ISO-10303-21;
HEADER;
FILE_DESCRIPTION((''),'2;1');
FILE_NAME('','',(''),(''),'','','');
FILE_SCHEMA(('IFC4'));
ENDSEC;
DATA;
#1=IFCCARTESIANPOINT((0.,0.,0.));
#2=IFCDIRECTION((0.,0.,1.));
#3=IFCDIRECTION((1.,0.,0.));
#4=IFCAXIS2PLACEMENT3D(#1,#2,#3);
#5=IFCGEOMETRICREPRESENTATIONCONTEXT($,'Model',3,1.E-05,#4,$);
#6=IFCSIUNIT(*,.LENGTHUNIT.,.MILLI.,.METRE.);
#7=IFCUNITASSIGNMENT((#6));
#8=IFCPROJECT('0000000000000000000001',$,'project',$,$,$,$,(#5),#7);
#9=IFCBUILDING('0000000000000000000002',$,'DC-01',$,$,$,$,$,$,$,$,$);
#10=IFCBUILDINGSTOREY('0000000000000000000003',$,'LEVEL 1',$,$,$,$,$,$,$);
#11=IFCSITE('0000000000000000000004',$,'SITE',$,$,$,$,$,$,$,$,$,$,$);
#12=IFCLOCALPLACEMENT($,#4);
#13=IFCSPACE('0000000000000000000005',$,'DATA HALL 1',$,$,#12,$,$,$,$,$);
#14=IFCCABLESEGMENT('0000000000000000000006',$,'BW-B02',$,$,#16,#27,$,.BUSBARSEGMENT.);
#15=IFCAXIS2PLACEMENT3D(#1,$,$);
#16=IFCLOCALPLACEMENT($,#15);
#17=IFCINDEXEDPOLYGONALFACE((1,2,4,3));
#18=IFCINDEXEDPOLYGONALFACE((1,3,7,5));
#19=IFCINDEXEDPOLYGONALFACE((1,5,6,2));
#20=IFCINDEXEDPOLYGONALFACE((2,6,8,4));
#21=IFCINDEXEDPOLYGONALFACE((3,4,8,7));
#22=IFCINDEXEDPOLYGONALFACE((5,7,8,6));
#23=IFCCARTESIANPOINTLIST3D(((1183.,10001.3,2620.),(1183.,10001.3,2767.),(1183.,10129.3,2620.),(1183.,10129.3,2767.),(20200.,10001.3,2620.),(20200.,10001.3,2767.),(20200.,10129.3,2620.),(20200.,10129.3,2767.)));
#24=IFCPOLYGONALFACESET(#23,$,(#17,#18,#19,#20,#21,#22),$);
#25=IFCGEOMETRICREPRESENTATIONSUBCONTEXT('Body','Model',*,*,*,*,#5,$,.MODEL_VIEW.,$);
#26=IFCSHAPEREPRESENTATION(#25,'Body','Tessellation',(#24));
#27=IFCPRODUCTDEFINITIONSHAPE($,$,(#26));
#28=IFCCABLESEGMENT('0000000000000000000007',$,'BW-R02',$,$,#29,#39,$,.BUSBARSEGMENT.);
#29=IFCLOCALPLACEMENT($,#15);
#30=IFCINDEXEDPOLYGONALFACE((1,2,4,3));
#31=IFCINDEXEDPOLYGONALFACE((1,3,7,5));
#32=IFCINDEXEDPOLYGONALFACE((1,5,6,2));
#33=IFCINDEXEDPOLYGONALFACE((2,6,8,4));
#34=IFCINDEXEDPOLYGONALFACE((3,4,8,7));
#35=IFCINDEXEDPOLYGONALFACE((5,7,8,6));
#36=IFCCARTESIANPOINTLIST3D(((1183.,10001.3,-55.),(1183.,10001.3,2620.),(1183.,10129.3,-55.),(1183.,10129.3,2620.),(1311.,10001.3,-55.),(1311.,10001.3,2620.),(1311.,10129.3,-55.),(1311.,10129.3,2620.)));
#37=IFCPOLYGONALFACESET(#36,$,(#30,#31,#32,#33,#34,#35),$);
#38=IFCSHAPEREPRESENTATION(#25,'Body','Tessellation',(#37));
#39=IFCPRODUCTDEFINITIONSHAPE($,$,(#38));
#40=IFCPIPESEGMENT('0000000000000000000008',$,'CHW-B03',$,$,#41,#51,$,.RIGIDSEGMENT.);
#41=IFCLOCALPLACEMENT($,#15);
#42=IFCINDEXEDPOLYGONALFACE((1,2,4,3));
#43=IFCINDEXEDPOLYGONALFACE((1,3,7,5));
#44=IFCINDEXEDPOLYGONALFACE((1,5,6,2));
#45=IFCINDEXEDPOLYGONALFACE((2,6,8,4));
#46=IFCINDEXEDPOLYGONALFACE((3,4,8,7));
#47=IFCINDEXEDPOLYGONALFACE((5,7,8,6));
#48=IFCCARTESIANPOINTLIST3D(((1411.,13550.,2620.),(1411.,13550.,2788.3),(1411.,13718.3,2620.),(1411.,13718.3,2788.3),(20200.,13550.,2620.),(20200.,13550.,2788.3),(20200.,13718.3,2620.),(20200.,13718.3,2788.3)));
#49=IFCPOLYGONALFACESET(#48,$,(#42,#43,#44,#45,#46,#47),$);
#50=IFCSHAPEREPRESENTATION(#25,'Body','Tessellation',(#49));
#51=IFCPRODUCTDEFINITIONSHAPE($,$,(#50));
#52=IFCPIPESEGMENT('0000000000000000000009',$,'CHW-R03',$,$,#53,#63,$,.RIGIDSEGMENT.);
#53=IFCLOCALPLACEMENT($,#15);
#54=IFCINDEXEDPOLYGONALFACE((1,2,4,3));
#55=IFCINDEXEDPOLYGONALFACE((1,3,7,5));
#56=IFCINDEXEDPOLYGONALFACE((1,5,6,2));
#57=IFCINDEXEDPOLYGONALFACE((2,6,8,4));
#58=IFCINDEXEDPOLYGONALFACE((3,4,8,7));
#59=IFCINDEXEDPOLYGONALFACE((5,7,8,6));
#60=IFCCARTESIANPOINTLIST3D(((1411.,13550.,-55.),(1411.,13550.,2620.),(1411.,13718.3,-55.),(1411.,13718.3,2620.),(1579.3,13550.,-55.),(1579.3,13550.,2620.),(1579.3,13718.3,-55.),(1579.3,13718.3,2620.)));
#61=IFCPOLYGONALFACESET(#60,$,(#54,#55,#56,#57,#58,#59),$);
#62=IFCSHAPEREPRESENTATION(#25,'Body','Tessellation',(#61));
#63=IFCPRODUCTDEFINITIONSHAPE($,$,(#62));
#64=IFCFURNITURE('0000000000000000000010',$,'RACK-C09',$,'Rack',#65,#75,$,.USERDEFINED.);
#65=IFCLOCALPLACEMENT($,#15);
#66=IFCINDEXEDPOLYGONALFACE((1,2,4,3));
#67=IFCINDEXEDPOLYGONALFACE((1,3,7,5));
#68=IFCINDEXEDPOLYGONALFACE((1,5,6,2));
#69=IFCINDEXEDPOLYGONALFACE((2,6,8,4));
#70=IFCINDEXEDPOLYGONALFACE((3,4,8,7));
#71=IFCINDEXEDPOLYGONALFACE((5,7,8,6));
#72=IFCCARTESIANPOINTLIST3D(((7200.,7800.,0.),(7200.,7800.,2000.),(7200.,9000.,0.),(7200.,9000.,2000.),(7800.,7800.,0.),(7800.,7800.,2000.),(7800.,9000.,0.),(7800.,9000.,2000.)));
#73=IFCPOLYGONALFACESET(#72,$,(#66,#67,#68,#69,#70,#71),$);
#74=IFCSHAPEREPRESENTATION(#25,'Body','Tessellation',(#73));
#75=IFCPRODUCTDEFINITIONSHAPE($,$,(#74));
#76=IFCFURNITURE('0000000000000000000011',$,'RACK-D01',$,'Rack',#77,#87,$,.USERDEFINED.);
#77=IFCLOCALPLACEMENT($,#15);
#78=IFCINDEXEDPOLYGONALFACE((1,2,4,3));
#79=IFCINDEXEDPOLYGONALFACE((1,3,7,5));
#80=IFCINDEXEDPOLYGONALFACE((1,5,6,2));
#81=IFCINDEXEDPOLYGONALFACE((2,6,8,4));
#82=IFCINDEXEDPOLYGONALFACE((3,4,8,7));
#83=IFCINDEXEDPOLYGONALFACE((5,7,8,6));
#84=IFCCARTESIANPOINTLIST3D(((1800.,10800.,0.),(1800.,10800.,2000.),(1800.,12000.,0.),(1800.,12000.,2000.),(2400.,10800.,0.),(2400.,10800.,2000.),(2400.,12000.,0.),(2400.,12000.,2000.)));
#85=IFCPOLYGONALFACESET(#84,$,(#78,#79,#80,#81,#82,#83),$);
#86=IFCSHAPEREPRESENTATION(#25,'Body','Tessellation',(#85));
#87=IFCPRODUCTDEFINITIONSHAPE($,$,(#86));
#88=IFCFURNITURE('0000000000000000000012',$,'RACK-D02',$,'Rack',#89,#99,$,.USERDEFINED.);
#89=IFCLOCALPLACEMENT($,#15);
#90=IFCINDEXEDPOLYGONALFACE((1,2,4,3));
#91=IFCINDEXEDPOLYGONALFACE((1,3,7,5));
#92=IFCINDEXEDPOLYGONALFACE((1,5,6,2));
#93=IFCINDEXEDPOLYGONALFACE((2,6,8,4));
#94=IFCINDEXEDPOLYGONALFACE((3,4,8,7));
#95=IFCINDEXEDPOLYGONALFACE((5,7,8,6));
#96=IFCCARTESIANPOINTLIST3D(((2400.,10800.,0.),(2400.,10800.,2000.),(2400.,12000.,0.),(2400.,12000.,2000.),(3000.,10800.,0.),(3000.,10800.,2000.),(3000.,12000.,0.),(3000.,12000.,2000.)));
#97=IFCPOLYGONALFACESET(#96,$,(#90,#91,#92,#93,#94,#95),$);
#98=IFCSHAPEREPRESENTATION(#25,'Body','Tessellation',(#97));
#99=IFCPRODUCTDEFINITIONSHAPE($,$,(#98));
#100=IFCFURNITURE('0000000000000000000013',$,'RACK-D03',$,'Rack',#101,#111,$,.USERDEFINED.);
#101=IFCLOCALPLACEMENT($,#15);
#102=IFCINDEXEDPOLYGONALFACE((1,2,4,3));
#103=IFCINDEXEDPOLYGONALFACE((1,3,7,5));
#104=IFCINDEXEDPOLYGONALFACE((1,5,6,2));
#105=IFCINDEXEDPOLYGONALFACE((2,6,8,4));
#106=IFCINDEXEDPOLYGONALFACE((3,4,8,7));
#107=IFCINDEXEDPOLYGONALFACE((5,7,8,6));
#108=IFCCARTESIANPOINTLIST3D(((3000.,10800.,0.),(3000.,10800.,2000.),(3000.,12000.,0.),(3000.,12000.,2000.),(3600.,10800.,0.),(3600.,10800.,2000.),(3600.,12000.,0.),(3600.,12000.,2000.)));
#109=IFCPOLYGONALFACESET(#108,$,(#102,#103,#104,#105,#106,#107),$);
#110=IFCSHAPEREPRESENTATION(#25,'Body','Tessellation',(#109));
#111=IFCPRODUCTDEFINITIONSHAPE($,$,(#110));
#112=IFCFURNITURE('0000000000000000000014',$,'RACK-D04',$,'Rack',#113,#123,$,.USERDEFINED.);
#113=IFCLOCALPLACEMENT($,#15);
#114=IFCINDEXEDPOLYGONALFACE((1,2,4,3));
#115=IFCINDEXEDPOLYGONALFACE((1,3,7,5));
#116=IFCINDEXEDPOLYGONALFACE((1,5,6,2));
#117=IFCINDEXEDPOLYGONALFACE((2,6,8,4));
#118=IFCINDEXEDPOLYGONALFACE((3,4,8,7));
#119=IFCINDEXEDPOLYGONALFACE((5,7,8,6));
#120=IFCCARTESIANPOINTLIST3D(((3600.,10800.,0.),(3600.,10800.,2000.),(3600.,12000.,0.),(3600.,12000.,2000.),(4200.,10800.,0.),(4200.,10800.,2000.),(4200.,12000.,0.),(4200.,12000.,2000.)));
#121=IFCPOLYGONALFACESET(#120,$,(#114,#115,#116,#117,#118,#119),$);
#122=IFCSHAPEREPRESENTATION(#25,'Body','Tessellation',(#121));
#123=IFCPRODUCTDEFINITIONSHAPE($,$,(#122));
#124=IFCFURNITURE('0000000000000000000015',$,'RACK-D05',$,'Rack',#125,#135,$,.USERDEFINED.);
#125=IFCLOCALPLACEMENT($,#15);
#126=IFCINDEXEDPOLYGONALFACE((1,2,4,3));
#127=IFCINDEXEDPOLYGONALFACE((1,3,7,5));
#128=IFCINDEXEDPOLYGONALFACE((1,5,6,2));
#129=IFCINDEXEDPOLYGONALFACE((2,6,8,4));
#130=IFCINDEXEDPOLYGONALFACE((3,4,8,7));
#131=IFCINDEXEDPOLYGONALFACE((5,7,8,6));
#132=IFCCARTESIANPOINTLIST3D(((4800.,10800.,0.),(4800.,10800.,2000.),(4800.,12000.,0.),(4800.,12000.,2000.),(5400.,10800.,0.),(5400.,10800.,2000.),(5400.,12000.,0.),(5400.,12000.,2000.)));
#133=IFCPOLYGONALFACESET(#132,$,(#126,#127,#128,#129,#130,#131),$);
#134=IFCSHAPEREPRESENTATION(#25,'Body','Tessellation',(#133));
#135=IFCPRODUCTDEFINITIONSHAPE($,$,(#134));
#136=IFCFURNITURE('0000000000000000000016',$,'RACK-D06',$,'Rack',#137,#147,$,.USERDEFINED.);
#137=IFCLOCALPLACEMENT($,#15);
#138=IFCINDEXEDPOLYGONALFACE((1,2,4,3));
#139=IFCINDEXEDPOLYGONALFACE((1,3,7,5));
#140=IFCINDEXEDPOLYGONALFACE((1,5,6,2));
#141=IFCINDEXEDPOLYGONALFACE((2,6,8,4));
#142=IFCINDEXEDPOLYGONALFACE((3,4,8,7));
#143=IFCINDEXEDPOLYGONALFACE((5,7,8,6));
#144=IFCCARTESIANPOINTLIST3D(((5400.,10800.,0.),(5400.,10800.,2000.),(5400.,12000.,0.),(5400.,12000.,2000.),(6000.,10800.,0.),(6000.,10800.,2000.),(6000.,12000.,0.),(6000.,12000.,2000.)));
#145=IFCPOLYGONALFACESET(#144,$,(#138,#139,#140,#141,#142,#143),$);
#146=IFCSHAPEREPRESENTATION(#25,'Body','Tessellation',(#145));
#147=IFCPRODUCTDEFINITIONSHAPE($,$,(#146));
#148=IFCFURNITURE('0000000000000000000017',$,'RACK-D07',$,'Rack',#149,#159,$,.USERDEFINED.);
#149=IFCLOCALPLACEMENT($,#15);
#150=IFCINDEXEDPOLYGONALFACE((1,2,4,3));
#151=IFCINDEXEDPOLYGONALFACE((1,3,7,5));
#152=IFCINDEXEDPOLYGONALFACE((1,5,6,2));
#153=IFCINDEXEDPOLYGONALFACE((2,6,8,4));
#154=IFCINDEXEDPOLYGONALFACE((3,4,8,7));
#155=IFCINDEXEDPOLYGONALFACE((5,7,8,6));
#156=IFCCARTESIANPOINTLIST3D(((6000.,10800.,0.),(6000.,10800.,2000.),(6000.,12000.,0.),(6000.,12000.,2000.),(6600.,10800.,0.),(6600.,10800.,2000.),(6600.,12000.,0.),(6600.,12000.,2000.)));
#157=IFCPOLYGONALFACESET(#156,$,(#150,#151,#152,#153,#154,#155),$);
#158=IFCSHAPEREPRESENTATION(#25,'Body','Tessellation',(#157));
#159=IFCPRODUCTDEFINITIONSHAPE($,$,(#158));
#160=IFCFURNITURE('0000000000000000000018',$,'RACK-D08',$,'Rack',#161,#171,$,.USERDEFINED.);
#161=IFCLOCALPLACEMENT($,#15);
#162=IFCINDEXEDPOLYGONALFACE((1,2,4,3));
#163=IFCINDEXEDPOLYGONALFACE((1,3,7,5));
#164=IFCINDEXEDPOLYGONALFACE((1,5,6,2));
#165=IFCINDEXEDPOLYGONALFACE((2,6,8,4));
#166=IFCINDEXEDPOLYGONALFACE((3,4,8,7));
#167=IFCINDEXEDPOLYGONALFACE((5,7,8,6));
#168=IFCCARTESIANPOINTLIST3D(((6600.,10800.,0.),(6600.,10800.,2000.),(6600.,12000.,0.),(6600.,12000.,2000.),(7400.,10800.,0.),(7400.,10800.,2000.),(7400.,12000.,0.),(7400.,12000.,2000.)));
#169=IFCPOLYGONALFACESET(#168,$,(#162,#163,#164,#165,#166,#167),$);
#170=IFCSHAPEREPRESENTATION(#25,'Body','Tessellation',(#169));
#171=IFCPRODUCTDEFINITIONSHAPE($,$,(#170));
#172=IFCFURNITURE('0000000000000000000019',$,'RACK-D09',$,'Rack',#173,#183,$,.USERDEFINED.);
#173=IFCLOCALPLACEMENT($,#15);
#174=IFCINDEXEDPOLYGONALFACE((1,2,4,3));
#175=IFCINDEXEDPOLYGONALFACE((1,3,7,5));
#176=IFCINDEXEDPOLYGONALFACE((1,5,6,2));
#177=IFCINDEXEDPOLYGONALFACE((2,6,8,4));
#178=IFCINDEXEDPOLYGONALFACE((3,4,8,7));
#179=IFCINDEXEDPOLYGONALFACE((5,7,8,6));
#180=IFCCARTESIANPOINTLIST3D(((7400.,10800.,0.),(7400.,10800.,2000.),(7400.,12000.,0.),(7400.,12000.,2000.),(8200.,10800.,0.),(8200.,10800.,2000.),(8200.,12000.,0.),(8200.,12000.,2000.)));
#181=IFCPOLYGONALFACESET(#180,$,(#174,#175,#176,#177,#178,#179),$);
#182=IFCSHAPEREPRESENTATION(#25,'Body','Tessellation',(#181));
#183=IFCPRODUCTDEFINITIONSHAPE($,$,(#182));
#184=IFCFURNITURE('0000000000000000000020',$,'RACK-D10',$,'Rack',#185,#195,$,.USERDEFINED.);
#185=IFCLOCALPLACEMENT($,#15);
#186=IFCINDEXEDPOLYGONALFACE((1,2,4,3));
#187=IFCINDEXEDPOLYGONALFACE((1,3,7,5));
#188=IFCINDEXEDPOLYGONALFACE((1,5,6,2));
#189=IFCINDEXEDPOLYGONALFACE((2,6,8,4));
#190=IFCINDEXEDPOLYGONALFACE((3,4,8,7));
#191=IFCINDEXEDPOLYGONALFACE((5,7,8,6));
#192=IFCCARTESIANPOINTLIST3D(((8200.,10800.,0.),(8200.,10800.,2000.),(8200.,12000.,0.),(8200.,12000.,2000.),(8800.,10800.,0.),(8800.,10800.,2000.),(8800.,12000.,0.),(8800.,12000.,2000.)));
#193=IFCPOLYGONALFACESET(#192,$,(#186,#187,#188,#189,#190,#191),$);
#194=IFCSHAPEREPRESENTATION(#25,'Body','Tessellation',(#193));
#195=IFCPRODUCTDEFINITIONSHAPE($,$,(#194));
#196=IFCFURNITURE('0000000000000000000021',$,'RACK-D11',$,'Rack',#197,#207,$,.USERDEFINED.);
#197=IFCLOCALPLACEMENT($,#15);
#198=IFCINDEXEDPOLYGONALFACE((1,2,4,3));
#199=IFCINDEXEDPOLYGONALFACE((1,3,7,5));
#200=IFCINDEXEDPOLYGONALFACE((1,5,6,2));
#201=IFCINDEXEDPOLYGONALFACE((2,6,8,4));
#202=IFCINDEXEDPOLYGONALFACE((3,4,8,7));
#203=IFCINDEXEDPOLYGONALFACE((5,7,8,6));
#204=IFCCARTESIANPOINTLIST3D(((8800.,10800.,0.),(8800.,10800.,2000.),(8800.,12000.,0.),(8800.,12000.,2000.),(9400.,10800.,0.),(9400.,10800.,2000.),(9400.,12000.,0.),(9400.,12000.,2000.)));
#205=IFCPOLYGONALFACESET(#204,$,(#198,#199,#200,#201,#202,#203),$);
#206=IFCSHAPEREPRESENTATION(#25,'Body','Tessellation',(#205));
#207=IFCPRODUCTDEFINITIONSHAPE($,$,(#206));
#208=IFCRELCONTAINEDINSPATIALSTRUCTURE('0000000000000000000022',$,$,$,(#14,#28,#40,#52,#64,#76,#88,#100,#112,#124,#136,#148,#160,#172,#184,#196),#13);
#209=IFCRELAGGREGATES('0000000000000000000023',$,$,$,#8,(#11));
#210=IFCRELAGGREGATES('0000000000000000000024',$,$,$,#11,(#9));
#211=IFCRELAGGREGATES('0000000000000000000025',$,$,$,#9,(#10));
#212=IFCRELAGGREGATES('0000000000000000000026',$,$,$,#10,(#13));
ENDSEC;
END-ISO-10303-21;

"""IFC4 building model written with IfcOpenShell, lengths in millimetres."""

from ifc_helpers import new_model, si_unit, frame, origin, origin_with_axes, place, context, subcontext, project, spatial, polyline, outline, extrude, element, save


model = new_model("IFC4")

# Units and contexts
model_context = context("Model", 3, precision=1e-05, world=origin_with_axes())
body_context = subcontext(model_context, "Body", "Model", "MODEL_VIEW")
ifc_project = project(units=[si_unit("LENGTHUNIT", "METRE", prefix="MILLI")], contexts=[model_context])

# Site, building, storey, space
site = spatial("IfcSite", under=ifc_project, Name="SITE")
building = spatial("IfcBuilding", under=site, Name="DC-01")
storey = spatial("IfcBuildingStorey", under=building, Name="LEVEL 1")
space_placement = place(None, origin_with_axes())
space = spatial("IfcSpace", under=storey, at=space_placement, Name="DATA HALL 1")

# Cable segments
cable_segment_1_placement = place(space_placement, frame((1183.0, 10001.3, 2620.0), z_axis=(0.0, 0.0, 1.0), x_axis=(1.0, 0.0, 0.0)))
element("IfcCableSegment", 1, at=cable_segment_1_placement, inside=space, Name="BW-B02", PredefinedType="BUSBARSEGMENT", context=body_context, shape_type="SweptSolid", body=[
    extrude(outline(polyline([(0.0, 0.0), (19017.0, 0.0), (19017.0, 128.0), (0.0, 128.0), (0.0, 0.0)])), origin(), (0.0, 0.0, 1.0), 147.0),
])
cable_segment_2_placement = place(space_placement, frame((1183.0, 10001.3, -55.0), z_axis=(0.0, 0.0, 1.0), x_axis=(1.0, 0.0, 0.0)))
element("IfcCableSegment", 2, at=cable_segment_2_placement, inside=space, Name="BW-R02", PredefinedType="BUSBARSEGMENT", context=body_context, shape_type="SweptSolid", body=[
    extrude(outline(polyline([(0.0, 0.0), (128.0, 0.0), (128.0, 128.0), (0.0, 128.0), (0.0, 0.0)])), origin(), (0.0, 0.0, 1.0), 2675.0),
])

# Pipe segments
pipe_segment_1_placement = place(space_placement, frame((1411.0, 13550.0, 2620.0), z_axis=(0.0, 0.0, 1.0), x_axis=(1.0, 0.0, 0.0)))
element("IfcPipeSegment", 3, at=pipe_segment_1_placement, inside=space, Name="CHW-B03", PredefinedType="RIGIDSEGMENT", context=body_context, shape_type="SweptSolid", body=[
    extrude(outline(polyline([(0.0, 0.0), (18789.0, 0.0), (18789.0, 168.3), (0.0, 168.3), (0.0, 0.0)])), origin(), (0.0, 0.0, 1.0), 168.3),
])
pipe_segment_2_placement = place(space_placement, frame((1411.0, 13550.0, -55.0), z_axis=(0.0, 0.0, 1.0), x_axis=(1.0, 0.0, 0.0)))
element("IfcPipeSegment", 4, at=pipe_segment_2_placement, inside=space, Name="CHW-R03", PredefinedType="RIGIDSEGMENT", context=body_context, shape_type="SweptSolid", body=[
    extrude(outline(polyline([(0.0, 0.0), (168.3, 0.0), (168.3, 168.3), (0.0, 168.3), (0.0, 0.0)])), origin(), (0.0, 0.0, 1.0), 2675.0),
])

# Furniture
for number, where, z_axis, x_axis, name in (
    (5, (7800.0, 9000.0, 0.0), (0.0, 0.0, 1.0), (-1.0, 0.0, 0.0), "RACK-C09"),
    (6, (1800.0, 10800.0, 0.0), (0.0, 0.0, 1.0), (1.0, 0.0, 0.0), "RACK-D01"),
    (7, (2400.0, 10800.0, 0.0), (0.0, 0.0, 1.0), (1.0, 0.0, 0.0), "RACK-D02"),
    (8, (3000.0, 10800.0, 0.0), (0.0, 0.0, 1.0), (1.0, 0.0, 0.0), "RACK-D03"),
    (9, (3600.0, 10800.0, 0.0), (0.0, 0.0, 1.0), (1.0, 0.0, 0.0), "RACK-D04"),
    (10, (4800.0, 10800.0, 0.0), (0.0, 0.0, 1.0), (1.0, 0.0, 0.0), "RACK-D05"),
    (11, (5400.0, 10800.0, 0.0), (0.0, 0.0, 1.0), (1.0, 0.0, 0.0), "RACK-D06"),
    (12, (6000.0, 10800.0, 0.0), (0.0, 0.0, 1.0), (1.0, 0.0, 0.0), "RACK-D07"),
):
    element("IfcFurniture", number, at=place(space_placement, frame(where, z_axis=z_axis, x_axis=x_axis)), inside=space, Name=name, ObjectType="Rack", PredefinedType="USERDEFINED", context=body_context, shape_type="SweptSolid", body=[
        extrude(outline(polyline([(0.0, 0.0), (600.0, 0.0), (600.0, 1200.0), (0.0, 1200.0), (0.0, 0.0)])), origin(), (0.0, 0.0, 1.0), 2000.0),
    ])
for number, where, z_axis, x_axis, name in (
    (13, (6600.0, 10800.0, 0.0), (0.0, 0.0, 1.0), (1.0, 0.0, 0.0), "RACK-D08"),
    (14, (7400.0, 10800.0, 0.0), (0.0, 0.0, 1.0), (1.0, 0.0, 0.0), "RACK-D09"),
):
    element("IfcFurniture", number, at=place(space_placement, frame(where, z_axis=z_axis, x_axis=x_axis)), inside=space, Name=name, ObjectType="Rack", PredefinedType="USERDEFINED", context=body_context, shape_type="SweptSolid", body=[
        extrude(outline(polyline([(0.0, 0.0), (800.0, 0.0), (800.0, 1200.0), (0.0, 1200.0), (0.0, 0.0)])), origin(), (0.0, 0.0, 1.0), 2000.0),
    ])
for number, where, z_axis, x_axis, name in (
    (15, (8200.0, 10800.0, 0.0), (0.0, 0.0, 1.0), (1.0, 0.0, 0.0), "RACK-D10"),
    (16, (8800.0, 10800.0, 0.0), (0.0, 0.0, 1.0), (1.0, 0.0, 0.0), "RACK-D11"),
):
    element("IfcFurniture", number, at=place(space_placement, frame(where, z_axis=z_axis, x_axis=x_axis)), inside=space, Name=name, ObjectType="Rack", PredefinedType="USERDEFINED", context=body_context, shape_type="SweptSolid", body=[
        extrude(outline(polyline([(0.0, 0.0), (600.0, 0.0), (600.0, 1200.0), (0.0, 1200.0), (0.0, 0.0)])), origin(), (0.0, 0.0, 1.0), 2000.0),
    ])

save(model, "model.ifc")
